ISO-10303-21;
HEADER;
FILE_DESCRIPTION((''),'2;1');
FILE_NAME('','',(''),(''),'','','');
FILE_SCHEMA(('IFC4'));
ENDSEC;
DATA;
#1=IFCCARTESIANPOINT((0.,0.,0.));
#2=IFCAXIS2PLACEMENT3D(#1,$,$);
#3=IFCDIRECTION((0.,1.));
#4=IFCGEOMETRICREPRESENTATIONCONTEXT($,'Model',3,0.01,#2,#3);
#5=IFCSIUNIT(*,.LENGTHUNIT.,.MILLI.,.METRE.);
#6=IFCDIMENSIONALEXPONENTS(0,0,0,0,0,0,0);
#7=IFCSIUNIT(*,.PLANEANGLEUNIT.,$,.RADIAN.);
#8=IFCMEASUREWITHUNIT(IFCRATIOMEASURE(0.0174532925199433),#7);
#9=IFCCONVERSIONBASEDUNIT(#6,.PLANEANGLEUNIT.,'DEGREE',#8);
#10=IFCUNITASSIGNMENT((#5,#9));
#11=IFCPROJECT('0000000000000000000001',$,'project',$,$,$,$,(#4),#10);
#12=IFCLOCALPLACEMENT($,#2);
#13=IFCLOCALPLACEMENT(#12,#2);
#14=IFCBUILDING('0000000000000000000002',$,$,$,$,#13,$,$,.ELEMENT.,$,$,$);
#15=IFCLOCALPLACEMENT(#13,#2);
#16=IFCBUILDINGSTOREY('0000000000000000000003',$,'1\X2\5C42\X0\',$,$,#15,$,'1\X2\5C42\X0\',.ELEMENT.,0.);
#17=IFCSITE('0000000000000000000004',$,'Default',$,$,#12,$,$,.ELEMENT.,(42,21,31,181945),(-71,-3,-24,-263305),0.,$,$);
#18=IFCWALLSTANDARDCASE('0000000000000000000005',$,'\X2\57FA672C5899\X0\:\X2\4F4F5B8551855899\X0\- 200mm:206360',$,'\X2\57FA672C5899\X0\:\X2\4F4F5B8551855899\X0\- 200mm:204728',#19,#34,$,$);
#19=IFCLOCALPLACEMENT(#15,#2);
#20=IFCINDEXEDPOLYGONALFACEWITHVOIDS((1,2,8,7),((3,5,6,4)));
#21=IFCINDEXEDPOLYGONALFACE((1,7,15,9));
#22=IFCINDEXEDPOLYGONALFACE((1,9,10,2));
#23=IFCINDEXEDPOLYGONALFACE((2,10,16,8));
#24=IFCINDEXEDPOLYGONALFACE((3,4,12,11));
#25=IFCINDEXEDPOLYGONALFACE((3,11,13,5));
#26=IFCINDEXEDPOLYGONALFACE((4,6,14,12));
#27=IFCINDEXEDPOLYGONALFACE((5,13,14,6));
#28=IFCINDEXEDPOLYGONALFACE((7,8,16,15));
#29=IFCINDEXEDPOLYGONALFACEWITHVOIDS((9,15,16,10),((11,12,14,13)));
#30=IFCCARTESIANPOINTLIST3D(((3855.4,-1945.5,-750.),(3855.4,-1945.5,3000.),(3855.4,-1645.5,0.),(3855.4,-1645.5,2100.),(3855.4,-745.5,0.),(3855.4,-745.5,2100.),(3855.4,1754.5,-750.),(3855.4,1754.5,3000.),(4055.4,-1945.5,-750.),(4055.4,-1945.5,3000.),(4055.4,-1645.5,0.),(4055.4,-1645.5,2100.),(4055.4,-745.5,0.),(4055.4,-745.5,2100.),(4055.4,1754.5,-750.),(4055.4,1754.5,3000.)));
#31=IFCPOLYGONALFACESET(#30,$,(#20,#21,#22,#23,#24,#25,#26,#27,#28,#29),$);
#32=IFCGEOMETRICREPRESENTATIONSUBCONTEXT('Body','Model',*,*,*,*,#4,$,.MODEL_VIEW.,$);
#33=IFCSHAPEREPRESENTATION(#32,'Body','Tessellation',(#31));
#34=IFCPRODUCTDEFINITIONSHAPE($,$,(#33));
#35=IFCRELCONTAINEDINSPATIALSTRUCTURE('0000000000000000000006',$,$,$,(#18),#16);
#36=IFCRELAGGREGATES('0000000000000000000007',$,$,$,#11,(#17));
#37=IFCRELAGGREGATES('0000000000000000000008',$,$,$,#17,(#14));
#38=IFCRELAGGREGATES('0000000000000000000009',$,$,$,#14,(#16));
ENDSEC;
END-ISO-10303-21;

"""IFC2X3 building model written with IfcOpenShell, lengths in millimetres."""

from ifc_helpers import new_model, entity, si_unit, converted_unit, direction, frame, frame_2d, origin, place, context, subcontext, project, spatial, rectangle, extrude, element, save


model = new_model("IFC2X3")

# Units and contexts
model_context = context("Model", 3, precision=0.01, world=origin(), true_north=direction((0.0, 1.0)))
body_context = subcontext(model_context, "Body", "Model", "MODEL_VIEW")
ifc_project = project(units=[si_unit("LENGTHUNIT", "METRE", prefix="MILLI"), converted_unit("PLANEANGLEUNIT", "DEGREE", entity("IfcRatioMeasure", 0.0174532925199433), si_unit("PLANEANGLEUNIT", "RADIAN"), dimensions=[0, 0, 0, 0, 0, 0, 0])], contexts=[model_context])

# Site, building, storey
site_placement = place(None, origin())
site = spatial("IfcSite", under=ifc_project, at=site_placement, Name="Default", CompositionType="ELEMENT", RefLatitude=(42, 21, 31, 181945), RefLongitude=(-71, -3, -24, -263305), RefElevation=0.0)
building_placement = place(site_placement, origin())
building = spatial("IfcBuilding", under=site, at=building_placement, CompositionType="ELEMENT")
storey_placement = place(building_placement, origin())
storey = spatial("IfcBuildingStorey", under=building, at=storey_placement, Name="1层", LongName="1层", CompositionType="ELEMENT", Elevation=0.0)

# Wall, opening
wall_1_placement = place(storey_placement, frame((3955.4, 1754.5, -750.0), z_axis=(0.0, 0.0, 1.0), x_axis=(0.0, -1.0, 0.0)))
wall_1 = element("IfcWallStandardCase", 1, at=wall_1_placement, inside=storey, Name="基本墙:住宅内墙- 200mm:206360", ObjectType="基本墙:住宅内墙- 200mm:204728", context=body_context, shape_type="SweptSolid", body=[
    extrude(rectangle(XDim=3700.0, YDim=200.0, at=frame_2d((1850.0, 0.0), x_axis=(-1.0, 0.0))), origin(), (0.0, 0.0, 1.0), 3750.0),
])
opening_1_placement = place(wall_1_placement, frame((2500.0, -100.0, 750.0)))
element("IfcOpeningElement", 2, at=opening_1_placement, cuts=wall_1, ObjectType="Opening", context=body_context, shape_type="SweptSolid", body=[
    extrude(rectangle(XDim=2100.0, YDim=900.0, at=frame_2d((1050.0, 450.0), x_axis=(1.0, 0.0))), frame((0.0, 0.0, 0.0), z_axis=(0.0, 1.0, 0.0), x_axis=(0.0, 0.0, 1.0)), (0.0, 0.0, 1.0), 200.0),
])

save(model, "model.ifc")
